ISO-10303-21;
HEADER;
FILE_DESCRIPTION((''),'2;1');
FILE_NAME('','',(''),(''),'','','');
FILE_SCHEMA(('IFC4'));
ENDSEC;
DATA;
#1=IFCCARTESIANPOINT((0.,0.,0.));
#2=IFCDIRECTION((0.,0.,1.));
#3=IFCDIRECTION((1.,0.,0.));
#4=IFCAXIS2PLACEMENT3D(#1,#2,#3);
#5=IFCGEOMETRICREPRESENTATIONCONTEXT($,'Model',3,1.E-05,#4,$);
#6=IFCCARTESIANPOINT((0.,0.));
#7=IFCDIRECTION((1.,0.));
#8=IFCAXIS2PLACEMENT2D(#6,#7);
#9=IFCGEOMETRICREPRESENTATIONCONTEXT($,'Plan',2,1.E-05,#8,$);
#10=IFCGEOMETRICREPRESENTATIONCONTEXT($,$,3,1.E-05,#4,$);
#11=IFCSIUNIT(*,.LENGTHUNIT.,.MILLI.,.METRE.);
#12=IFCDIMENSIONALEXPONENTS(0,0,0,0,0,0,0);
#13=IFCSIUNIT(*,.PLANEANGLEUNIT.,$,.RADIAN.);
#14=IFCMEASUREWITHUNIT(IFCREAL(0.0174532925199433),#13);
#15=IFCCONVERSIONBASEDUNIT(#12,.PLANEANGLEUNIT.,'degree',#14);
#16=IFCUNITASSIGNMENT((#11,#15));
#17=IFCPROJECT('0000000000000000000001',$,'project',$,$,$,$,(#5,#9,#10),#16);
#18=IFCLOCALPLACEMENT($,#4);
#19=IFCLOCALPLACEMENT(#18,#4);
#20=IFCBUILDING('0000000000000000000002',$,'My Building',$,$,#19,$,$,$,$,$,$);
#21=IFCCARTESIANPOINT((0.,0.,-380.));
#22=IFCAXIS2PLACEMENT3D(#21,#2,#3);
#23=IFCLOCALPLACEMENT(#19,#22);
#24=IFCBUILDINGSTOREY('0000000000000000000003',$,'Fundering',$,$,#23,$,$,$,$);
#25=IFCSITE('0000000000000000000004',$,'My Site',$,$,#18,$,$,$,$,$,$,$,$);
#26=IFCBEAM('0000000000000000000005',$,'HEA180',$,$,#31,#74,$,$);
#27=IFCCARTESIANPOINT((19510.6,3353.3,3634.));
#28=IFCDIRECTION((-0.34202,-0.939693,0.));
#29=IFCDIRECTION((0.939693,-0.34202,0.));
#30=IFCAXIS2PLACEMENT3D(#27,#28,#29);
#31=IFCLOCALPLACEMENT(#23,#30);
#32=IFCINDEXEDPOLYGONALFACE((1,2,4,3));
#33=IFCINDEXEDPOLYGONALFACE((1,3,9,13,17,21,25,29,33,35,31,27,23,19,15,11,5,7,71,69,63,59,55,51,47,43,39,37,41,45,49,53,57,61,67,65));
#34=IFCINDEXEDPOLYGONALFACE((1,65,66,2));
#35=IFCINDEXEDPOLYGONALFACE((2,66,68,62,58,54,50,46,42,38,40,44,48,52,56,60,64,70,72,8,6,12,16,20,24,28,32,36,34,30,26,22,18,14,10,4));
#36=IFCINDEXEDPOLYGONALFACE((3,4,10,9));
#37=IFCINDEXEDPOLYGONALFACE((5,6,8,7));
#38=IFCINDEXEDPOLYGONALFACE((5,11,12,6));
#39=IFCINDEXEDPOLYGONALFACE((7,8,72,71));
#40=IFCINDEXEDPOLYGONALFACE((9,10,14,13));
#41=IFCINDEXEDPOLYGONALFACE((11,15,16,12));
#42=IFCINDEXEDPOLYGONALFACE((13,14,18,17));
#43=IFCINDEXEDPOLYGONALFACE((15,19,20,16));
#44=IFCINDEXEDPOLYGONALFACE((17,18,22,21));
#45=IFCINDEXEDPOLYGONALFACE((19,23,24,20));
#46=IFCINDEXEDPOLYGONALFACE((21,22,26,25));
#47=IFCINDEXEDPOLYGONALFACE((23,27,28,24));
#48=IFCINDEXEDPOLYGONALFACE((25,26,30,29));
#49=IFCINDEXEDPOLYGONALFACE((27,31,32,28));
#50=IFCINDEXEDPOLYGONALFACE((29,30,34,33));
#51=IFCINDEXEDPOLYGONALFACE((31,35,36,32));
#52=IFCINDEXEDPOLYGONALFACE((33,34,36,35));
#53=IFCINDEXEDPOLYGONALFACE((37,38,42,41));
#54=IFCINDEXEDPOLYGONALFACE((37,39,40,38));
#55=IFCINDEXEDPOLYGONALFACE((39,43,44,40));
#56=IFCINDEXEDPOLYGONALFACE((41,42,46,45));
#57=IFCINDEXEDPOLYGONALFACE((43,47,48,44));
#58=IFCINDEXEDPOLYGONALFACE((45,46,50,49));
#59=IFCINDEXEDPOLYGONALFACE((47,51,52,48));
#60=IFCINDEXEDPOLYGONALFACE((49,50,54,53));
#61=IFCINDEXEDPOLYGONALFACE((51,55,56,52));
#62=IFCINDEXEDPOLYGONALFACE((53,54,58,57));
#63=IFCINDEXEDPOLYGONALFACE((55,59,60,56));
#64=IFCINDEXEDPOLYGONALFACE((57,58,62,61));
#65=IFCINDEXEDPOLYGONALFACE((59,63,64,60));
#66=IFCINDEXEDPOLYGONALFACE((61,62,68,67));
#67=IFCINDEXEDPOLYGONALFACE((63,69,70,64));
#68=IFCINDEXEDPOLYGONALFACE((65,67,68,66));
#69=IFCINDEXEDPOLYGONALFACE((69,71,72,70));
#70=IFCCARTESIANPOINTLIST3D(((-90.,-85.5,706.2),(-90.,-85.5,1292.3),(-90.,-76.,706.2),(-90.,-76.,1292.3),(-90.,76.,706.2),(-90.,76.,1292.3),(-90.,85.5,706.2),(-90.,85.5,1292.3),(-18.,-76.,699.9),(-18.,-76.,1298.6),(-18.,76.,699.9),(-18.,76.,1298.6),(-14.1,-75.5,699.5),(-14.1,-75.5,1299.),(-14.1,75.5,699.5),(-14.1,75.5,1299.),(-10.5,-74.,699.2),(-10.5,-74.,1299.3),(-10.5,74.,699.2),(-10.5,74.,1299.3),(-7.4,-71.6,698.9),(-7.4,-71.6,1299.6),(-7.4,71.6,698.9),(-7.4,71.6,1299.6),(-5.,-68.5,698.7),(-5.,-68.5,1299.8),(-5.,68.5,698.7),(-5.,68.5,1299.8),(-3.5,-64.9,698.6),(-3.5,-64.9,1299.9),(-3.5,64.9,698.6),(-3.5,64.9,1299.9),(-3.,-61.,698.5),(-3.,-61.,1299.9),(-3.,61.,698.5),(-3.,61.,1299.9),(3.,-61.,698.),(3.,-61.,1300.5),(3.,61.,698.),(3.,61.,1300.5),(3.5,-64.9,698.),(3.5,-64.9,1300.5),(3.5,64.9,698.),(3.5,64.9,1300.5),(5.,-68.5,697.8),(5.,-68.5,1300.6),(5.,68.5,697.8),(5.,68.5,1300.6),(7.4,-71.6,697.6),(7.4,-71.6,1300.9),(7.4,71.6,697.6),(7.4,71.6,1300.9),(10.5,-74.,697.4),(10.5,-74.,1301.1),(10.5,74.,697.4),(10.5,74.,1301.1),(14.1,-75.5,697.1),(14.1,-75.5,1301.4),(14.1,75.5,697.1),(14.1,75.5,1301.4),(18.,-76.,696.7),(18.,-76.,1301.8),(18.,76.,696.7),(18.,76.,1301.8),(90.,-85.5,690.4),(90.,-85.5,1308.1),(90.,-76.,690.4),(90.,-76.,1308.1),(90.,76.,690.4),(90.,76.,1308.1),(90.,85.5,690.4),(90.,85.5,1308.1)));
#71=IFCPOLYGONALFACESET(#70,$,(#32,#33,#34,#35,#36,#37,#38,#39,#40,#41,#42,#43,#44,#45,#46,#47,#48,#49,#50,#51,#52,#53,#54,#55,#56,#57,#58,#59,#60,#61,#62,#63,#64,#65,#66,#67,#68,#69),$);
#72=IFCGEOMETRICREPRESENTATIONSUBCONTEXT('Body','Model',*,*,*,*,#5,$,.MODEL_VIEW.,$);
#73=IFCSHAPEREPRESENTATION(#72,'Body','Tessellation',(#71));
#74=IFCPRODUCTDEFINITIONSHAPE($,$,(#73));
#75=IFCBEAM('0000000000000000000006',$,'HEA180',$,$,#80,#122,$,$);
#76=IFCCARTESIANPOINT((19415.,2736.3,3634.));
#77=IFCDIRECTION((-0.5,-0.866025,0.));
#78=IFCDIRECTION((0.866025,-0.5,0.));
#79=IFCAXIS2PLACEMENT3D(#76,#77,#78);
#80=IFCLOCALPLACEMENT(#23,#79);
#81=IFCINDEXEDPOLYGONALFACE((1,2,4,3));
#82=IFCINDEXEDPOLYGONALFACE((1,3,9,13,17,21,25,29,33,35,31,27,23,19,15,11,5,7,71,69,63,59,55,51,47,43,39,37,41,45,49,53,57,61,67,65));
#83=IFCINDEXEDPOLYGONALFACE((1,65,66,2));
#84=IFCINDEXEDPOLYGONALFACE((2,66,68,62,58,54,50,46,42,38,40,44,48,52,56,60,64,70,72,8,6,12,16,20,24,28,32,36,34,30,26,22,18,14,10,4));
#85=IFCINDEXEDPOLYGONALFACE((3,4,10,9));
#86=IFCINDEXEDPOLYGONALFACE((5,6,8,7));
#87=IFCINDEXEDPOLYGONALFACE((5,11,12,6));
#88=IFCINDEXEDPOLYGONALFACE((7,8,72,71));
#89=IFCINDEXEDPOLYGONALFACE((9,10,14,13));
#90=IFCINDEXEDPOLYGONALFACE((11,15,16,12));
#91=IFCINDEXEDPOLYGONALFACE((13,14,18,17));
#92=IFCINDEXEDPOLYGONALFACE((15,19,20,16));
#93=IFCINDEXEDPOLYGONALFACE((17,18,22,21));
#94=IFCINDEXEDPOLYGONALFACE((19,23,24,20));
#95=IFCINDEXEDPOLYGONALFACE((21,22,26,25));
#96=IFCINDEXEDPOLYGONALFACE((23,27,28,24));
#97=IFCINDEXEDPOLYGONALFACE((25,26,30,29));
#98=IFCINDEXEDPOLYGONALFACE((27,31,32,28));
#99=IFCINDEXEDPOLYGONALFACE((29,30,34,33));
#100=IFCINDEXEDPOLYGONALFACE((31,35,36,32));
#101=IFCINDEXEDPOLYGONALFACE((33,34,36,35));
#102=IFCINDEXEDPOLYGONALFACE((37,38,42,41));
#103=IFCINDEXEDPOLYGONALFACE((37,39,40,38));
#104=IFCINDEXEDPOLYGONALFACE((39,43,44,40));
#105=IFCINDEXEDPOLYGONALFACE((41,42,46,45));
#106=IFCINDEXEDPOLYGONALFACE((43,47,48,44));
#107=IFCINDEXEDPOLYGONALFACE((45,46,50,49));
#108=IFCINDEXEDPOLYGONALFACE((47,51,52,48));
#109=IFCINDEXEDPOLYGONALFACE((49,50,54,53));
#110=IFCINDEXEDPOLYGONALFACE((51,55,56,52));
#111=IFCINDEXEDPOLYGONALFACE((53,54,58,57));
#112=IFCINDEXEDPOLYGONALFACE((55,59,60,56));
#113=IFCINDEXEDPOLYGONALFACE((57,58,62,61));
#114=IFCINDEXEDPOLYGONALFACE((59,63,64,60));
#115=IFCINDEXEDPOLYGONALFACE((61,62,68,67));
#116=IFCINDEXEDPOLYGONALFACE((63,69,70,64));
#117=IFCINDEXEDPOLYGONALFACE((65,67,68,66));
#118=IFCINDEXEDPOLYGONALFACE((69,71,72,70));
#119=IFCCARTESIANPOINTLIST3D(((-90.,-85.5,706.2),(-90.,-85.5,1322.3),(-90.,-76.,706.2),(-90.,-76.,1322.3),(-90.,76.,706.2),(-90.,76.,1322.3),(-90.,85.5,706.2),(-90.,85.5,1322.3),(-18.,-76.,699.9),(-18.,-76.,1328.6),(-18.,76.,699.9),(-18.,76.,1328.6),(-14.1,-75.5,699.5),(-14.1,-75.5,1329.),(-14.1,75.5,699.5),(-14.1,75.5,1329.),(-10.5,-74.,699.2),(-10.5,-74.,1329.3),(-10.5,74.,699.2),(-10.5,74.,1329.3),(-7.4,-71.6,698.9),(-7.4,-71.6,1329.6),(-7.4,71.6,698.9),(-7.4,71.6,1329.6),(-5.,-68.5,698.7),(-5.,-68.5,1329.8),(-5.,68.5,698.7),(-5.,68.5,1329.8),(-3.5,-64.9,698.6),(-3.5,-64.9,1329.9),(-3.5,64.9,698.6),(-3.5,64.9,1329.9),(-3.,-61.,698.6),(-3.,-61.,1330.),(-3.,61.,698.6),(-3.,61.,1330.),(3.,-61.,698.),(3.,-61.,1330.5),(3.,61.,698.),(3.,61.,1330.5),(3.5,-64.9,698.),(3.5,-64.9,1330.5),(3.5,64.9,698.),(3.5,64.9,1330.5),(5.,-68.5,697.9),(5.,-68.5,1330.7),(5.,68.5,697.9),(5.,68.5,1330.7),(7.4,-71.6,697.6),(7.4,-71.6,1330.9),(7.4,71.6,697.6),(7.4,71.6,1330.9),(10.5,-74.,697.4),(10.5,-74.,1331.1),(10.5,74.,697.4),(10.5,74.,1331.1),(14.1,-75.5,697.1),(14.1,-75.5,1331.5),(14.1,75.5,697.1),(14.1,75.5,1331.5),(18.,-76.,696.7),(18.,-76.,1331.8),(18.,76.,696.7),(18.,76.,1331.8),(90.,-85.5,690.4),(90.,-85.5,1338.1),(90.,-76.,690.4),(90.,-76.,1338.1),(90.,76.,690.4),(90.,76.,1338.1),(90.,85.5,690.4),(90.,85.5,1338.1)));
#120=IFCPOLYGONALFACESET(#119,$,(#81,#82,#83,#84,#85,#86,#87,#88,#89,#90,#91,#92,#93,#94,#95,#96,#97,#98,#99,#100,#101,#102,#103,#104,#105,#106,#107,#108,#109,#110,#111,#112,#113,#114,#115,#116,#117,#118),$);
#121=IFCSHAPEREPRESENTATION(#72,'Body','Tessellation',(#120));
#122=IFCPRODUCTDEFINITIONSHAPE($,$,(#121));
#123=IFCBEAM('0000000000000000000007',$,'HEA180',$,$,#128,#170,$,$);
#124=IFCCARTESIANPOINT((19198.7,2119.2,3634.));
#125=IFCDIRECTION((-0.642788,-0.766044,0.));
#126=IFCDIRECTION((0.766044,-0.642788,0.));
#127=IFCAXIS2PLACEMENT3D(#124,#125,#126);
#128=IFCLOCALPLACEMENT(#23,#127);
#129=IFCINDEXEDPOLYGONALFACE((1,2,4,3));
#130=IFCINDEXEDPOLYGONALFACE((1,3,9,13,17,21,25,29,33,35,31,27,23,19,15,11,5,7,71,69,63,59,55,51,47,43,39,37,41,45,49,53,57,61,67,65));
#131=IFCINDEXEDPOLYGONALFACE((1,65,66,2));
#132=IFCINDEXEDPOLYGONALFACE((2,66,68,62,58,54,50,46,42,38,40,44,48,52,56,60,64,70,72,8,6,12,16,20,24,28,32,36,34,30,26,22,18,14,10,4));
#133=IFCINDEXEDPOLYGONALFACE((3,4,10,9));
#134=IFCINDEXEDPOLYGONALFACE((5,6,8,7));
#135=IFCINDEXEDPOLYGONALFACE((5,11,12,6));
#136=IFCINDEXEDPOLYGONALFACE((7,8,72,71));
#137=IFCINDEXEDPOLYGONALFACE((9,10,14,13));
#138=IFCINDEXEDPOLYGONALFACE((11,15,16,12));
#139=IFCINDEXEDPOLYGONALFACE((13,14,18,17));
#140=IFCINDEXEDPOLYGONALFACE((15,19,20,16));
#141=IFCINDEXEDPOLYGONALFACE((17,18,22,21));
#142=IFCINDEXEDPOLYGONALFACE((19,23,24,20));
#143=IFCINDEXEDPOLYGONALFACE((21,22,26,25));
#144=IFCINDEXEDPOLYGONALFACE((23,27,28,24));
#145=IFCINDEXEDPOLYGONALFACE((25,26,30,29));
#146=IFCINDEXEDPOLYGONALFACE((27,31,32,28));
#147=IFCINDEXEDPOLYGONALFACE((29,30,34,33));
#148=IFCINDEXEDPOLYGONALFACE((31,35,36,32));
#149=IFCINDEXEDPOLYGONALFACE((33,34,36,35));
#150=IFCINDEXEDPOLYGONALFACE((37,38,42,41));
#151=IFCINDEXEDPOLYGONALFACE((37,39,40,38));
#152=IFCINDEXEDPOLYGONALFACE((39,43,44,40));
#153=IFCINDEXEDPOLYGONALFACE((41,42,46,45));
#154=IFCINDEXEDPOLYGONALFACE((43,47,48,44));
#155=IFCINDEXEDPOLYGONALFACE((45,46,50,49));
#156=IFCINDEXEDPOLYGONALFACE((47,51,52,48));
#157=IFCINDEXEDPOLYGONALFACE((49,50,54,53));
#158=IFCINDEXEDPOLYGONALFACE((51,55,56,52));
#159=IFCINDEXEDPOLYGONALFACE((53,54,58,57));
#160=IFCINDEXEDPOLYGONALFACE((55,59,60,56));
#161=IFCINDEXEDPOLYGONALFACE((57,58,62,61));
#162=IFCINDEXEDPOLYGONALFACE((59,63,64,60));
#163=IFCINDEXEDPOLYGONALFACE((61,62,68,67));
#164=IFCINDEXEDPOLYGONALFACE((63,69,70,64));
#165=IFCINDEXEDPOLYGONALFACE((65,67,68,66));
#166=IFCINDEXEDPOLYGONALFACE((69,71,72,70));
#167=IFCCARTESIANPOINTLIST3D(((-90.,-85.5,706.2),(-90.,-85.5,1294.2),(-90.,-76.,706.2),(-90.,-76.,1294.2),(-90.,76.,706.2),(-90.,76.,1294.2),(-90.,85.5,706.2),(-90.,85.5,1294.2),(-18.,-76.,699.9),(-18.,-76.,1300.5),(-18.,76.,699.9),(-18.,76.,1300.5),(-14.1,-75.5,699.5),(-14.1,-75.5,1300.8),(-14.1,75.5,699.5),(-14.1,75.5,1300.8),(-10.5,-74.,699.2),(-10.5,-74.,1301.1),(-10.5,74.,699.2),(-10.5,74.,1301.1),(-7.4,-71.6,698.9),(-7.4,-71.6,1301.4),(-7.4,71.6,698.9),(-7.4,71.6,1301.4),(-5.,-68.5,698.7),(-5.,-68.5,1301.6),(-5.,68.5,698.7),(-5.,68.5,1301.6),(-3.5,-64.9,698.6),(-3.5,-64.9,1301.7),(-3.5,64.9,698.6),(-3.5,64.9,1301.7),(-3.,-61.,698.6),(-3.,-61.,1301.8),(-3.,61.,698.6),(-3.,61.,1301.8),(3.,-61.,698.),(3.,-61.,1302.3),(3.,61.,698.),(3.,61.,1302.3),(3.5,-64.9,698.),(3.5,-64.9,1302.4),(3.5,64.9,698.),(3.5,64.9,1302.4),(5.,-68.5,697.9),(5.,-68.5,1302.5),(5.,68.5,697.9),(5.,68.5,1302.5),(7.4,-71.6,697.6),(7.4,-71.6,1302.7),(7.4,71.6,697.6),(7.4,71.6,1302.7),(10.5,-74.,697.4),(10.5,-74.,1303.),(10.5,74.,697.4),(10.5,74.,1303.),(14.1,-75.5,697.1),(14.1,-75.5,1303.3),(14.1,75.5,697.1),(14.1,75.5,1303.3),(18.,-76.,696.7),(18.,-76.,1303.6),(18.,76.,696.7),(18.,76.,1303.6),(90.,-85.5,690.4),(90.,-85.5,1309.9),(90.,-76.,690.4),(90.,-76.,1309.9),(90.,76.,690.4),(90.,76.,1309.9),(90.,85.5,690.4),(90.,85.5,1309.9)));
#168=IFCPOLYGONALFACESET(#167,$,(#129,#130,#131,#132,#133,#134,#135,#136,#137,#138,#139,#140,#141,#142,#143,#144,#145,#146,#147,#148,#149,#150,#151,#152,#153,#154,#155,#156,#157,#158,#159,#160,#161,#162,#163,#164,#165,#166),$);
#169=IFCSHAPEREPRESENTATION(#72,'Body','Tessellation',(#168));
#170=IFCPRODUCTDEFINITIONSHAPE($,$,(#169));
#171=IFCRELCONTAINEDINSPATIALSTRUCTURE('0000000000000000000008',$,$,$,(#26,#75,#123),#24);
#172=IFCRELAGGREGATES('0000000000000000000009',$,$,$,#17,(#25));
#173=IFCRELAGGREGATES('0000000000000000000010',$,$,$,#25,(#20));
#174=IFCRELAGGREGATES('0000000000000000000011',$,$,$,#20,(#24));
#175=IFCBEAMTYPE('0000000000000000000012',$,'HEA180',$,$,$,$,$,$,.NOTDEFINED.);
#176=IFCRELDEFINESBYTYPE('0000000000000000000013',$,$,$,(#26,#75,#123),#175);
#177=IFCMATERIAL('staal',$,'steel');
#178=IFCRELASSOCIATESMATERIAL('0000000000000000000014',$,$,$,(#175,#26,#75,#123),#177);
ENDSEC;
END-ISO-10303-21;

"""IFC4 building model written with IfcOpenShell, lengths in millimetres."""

from ifc_helpers import new_model, entity, si_unit, converted_unit, frame, origin_with_axes, origin_2d_with_axis, place, context, subcontext, project, spatial, i_section, extrude, clip, halfspace, material, material_profile, profile_set, profile_usage, type_object, element, save


model = new_model("IFC4")

# Units and contexts
model_context = context("Model", 3, precision=1e-05, world=origin_with_axes())
plan_context = context("Plan", 2, precision=1e-05, world=origin_2d_with_axis())
context_of_model = context(None, 3, precision=1e-05, world=origin_with_axes())
body_context = subcontext(model_context, "Body", "Model", "MODEL_VIEW")
ifc_project = project(units=[si_unit("LENGTHUNIT", "METRE", prefix="MILLI"), converted_unit("PLANEANGLEUNIT", "degree", entity("IfcReal", 0.0174532925199433), si_unit("PLANEANGLEUNIT", "RADIAN"), dimensions=[0, 0, 0, 0, 0, 0, 0])], contexts=[model_context, plan_context, context_of_model])

# Site, building, storey
site_placement = place(None, origin_with_axes())
site = spatial("IfcSite", under=ifc_project, at=site_placement, Name="My Site")
building_placement = place(site_placement, origin_with_axes())
building = spatial("IfcBuilding", under=site, at=building_placement, Name="My Building")
storey_placement = place(building_placement, frame((0.0, 0.0, -380.0), z_axis=(0.0, 0.0, 1.0), x_axis=(1.0, 0.0, 0.0)))
storey = spatial("IfcBuildingStorey", under=building, at=storey_placement, Name="Fundering")

# Shared definitions
ifc_material_1 = material(Name="staal", Category="steel")

# Beams
ifc_material_profile_1 = material_profile(ifc_material_1, i_section(OverallWidth=180.0, OverallDepth=171.0, WebThickness=6.0, FlangeThickness=9.5, FilletRadius=15.0))
ifc_profile_set_1 = profile_set([ifc_material_profile_1], Name="HEA180")
beam_type_1 = type_object("IfcBeamType", Name="HEA180", PredefinedType="NOTDEFINED", material=ifc_profile_set_1)
ifc_profile_usage_1 = profile_usage(ifc_profile_set_1)
beam_1_placement = place(storey_placement, frame((19510.6, 3353.3, 3634.0), z_axis=(-0.34202, -0.939693, 0.0), x_axis=(0.939693, -0.34202, 0.0)))
element("IfcBeam", 1, at=beam_1_placement, inside=storey, type_object=beam_type_1, material=ifc_profile_usage_1, Name="HEA180", context=body_context, shape_type="Clipping", body=[
    clip(clip(extrude(i_section(OverallWidth=180.0, OverallDepth=171.0, WebThickness=6.0, FlangeThickness=9.5, FilletRadius=15.0), origin_with_axes(), (0.0, 0.0, 1.0), 1998.5), halfspace(frame((90.0, -3254.0, 690.4), z_axis=(-0.087136, 0.0, -0.996196), x_axis=(0.0, 1.0, 0.0)), False)), halfspace(frame((90.0, -3254.0, 1308.1), z_axis=(-0.087123, 0.0, 0.996197), x_axis=(-0.000001, 1.0, 0.0)), False)),
])
ifc_profile_usage_2 = profile_usage(ifc_profile_set_1)
beam_2_placement = place(storey_placement, frame((19415.0, 2736.3, 3634.0), z_axis=(-0.5, -0.866025, 0.0), x_axis=(0.866025, -0.5, 0.0)))
element("IfcBeam", 2, at=beam_2_placement, inside=storey, type_object=beam_type_1, material=ifc_profile_usage_2, Name="HEA180", context=body_context, shape_type="Clipping", body=[
    clip(clip(extrude(i_section(OverallWidth=180.0, OverallDepth=171.0, WebThickness=6.0, FlangeThickness=9.5, FilletRadius=15.0), origin_with_axes(), (0.0, 0.0, 1.0), 2028.5), halfspace(frame((90.0, -3254.0, 690.4), z_axis=(-0.087187, 0.0, -0.996192), x_axis=(0.000001, 1.0, 0.0)), False)), halfspace(frame((90.0, -3254.0, 1338.1), z_axis=(-0.087204, 0.0, 0.99619), x_axis=(-0.000001, 1.0, 0.0)), False)),
])
ifc_profile_usage_3 = profile_usage(ifc_profile_set_1)
beam_3_placement = place(storey_placement, frame((19198.7, 2119.2, 3634.0), z_axis=(-0.642788, -0.766044, 0.0), x_axis=(0.766044, -0.642788, 0.0)))
element("IfcBeam", 3, at=beam_3_placement, inside=storey, type_object=beam_type_1, material=ifc_profile_usage_3, Name="HEA180", context=body_context, shape_type="Clipping", body=[
    clip(clip(extrude(i_section(OverallWidth=180.0, OverallDepth=171.0, WebThickness=6.0, FlangeThickness=9.5, FilletRadius=15.0), origin_with_axes(), (0.0, 0.0, 1.0), 2000.3), halfspace(frame((90.0, -3254.0, 690.4), z_axis=(-0.087149, 0.0, -0.996195), x_axis=(0.000001, 1.0, 0.0)), False)), halfspace(frame((90.0, -3254.0, 1309.9), z_axis=(-0.087193, 0.0, 0.996191), x_axis=(-0.000001, 1.0, 0.0)), False)),
])

save(model, "model.ifc")
